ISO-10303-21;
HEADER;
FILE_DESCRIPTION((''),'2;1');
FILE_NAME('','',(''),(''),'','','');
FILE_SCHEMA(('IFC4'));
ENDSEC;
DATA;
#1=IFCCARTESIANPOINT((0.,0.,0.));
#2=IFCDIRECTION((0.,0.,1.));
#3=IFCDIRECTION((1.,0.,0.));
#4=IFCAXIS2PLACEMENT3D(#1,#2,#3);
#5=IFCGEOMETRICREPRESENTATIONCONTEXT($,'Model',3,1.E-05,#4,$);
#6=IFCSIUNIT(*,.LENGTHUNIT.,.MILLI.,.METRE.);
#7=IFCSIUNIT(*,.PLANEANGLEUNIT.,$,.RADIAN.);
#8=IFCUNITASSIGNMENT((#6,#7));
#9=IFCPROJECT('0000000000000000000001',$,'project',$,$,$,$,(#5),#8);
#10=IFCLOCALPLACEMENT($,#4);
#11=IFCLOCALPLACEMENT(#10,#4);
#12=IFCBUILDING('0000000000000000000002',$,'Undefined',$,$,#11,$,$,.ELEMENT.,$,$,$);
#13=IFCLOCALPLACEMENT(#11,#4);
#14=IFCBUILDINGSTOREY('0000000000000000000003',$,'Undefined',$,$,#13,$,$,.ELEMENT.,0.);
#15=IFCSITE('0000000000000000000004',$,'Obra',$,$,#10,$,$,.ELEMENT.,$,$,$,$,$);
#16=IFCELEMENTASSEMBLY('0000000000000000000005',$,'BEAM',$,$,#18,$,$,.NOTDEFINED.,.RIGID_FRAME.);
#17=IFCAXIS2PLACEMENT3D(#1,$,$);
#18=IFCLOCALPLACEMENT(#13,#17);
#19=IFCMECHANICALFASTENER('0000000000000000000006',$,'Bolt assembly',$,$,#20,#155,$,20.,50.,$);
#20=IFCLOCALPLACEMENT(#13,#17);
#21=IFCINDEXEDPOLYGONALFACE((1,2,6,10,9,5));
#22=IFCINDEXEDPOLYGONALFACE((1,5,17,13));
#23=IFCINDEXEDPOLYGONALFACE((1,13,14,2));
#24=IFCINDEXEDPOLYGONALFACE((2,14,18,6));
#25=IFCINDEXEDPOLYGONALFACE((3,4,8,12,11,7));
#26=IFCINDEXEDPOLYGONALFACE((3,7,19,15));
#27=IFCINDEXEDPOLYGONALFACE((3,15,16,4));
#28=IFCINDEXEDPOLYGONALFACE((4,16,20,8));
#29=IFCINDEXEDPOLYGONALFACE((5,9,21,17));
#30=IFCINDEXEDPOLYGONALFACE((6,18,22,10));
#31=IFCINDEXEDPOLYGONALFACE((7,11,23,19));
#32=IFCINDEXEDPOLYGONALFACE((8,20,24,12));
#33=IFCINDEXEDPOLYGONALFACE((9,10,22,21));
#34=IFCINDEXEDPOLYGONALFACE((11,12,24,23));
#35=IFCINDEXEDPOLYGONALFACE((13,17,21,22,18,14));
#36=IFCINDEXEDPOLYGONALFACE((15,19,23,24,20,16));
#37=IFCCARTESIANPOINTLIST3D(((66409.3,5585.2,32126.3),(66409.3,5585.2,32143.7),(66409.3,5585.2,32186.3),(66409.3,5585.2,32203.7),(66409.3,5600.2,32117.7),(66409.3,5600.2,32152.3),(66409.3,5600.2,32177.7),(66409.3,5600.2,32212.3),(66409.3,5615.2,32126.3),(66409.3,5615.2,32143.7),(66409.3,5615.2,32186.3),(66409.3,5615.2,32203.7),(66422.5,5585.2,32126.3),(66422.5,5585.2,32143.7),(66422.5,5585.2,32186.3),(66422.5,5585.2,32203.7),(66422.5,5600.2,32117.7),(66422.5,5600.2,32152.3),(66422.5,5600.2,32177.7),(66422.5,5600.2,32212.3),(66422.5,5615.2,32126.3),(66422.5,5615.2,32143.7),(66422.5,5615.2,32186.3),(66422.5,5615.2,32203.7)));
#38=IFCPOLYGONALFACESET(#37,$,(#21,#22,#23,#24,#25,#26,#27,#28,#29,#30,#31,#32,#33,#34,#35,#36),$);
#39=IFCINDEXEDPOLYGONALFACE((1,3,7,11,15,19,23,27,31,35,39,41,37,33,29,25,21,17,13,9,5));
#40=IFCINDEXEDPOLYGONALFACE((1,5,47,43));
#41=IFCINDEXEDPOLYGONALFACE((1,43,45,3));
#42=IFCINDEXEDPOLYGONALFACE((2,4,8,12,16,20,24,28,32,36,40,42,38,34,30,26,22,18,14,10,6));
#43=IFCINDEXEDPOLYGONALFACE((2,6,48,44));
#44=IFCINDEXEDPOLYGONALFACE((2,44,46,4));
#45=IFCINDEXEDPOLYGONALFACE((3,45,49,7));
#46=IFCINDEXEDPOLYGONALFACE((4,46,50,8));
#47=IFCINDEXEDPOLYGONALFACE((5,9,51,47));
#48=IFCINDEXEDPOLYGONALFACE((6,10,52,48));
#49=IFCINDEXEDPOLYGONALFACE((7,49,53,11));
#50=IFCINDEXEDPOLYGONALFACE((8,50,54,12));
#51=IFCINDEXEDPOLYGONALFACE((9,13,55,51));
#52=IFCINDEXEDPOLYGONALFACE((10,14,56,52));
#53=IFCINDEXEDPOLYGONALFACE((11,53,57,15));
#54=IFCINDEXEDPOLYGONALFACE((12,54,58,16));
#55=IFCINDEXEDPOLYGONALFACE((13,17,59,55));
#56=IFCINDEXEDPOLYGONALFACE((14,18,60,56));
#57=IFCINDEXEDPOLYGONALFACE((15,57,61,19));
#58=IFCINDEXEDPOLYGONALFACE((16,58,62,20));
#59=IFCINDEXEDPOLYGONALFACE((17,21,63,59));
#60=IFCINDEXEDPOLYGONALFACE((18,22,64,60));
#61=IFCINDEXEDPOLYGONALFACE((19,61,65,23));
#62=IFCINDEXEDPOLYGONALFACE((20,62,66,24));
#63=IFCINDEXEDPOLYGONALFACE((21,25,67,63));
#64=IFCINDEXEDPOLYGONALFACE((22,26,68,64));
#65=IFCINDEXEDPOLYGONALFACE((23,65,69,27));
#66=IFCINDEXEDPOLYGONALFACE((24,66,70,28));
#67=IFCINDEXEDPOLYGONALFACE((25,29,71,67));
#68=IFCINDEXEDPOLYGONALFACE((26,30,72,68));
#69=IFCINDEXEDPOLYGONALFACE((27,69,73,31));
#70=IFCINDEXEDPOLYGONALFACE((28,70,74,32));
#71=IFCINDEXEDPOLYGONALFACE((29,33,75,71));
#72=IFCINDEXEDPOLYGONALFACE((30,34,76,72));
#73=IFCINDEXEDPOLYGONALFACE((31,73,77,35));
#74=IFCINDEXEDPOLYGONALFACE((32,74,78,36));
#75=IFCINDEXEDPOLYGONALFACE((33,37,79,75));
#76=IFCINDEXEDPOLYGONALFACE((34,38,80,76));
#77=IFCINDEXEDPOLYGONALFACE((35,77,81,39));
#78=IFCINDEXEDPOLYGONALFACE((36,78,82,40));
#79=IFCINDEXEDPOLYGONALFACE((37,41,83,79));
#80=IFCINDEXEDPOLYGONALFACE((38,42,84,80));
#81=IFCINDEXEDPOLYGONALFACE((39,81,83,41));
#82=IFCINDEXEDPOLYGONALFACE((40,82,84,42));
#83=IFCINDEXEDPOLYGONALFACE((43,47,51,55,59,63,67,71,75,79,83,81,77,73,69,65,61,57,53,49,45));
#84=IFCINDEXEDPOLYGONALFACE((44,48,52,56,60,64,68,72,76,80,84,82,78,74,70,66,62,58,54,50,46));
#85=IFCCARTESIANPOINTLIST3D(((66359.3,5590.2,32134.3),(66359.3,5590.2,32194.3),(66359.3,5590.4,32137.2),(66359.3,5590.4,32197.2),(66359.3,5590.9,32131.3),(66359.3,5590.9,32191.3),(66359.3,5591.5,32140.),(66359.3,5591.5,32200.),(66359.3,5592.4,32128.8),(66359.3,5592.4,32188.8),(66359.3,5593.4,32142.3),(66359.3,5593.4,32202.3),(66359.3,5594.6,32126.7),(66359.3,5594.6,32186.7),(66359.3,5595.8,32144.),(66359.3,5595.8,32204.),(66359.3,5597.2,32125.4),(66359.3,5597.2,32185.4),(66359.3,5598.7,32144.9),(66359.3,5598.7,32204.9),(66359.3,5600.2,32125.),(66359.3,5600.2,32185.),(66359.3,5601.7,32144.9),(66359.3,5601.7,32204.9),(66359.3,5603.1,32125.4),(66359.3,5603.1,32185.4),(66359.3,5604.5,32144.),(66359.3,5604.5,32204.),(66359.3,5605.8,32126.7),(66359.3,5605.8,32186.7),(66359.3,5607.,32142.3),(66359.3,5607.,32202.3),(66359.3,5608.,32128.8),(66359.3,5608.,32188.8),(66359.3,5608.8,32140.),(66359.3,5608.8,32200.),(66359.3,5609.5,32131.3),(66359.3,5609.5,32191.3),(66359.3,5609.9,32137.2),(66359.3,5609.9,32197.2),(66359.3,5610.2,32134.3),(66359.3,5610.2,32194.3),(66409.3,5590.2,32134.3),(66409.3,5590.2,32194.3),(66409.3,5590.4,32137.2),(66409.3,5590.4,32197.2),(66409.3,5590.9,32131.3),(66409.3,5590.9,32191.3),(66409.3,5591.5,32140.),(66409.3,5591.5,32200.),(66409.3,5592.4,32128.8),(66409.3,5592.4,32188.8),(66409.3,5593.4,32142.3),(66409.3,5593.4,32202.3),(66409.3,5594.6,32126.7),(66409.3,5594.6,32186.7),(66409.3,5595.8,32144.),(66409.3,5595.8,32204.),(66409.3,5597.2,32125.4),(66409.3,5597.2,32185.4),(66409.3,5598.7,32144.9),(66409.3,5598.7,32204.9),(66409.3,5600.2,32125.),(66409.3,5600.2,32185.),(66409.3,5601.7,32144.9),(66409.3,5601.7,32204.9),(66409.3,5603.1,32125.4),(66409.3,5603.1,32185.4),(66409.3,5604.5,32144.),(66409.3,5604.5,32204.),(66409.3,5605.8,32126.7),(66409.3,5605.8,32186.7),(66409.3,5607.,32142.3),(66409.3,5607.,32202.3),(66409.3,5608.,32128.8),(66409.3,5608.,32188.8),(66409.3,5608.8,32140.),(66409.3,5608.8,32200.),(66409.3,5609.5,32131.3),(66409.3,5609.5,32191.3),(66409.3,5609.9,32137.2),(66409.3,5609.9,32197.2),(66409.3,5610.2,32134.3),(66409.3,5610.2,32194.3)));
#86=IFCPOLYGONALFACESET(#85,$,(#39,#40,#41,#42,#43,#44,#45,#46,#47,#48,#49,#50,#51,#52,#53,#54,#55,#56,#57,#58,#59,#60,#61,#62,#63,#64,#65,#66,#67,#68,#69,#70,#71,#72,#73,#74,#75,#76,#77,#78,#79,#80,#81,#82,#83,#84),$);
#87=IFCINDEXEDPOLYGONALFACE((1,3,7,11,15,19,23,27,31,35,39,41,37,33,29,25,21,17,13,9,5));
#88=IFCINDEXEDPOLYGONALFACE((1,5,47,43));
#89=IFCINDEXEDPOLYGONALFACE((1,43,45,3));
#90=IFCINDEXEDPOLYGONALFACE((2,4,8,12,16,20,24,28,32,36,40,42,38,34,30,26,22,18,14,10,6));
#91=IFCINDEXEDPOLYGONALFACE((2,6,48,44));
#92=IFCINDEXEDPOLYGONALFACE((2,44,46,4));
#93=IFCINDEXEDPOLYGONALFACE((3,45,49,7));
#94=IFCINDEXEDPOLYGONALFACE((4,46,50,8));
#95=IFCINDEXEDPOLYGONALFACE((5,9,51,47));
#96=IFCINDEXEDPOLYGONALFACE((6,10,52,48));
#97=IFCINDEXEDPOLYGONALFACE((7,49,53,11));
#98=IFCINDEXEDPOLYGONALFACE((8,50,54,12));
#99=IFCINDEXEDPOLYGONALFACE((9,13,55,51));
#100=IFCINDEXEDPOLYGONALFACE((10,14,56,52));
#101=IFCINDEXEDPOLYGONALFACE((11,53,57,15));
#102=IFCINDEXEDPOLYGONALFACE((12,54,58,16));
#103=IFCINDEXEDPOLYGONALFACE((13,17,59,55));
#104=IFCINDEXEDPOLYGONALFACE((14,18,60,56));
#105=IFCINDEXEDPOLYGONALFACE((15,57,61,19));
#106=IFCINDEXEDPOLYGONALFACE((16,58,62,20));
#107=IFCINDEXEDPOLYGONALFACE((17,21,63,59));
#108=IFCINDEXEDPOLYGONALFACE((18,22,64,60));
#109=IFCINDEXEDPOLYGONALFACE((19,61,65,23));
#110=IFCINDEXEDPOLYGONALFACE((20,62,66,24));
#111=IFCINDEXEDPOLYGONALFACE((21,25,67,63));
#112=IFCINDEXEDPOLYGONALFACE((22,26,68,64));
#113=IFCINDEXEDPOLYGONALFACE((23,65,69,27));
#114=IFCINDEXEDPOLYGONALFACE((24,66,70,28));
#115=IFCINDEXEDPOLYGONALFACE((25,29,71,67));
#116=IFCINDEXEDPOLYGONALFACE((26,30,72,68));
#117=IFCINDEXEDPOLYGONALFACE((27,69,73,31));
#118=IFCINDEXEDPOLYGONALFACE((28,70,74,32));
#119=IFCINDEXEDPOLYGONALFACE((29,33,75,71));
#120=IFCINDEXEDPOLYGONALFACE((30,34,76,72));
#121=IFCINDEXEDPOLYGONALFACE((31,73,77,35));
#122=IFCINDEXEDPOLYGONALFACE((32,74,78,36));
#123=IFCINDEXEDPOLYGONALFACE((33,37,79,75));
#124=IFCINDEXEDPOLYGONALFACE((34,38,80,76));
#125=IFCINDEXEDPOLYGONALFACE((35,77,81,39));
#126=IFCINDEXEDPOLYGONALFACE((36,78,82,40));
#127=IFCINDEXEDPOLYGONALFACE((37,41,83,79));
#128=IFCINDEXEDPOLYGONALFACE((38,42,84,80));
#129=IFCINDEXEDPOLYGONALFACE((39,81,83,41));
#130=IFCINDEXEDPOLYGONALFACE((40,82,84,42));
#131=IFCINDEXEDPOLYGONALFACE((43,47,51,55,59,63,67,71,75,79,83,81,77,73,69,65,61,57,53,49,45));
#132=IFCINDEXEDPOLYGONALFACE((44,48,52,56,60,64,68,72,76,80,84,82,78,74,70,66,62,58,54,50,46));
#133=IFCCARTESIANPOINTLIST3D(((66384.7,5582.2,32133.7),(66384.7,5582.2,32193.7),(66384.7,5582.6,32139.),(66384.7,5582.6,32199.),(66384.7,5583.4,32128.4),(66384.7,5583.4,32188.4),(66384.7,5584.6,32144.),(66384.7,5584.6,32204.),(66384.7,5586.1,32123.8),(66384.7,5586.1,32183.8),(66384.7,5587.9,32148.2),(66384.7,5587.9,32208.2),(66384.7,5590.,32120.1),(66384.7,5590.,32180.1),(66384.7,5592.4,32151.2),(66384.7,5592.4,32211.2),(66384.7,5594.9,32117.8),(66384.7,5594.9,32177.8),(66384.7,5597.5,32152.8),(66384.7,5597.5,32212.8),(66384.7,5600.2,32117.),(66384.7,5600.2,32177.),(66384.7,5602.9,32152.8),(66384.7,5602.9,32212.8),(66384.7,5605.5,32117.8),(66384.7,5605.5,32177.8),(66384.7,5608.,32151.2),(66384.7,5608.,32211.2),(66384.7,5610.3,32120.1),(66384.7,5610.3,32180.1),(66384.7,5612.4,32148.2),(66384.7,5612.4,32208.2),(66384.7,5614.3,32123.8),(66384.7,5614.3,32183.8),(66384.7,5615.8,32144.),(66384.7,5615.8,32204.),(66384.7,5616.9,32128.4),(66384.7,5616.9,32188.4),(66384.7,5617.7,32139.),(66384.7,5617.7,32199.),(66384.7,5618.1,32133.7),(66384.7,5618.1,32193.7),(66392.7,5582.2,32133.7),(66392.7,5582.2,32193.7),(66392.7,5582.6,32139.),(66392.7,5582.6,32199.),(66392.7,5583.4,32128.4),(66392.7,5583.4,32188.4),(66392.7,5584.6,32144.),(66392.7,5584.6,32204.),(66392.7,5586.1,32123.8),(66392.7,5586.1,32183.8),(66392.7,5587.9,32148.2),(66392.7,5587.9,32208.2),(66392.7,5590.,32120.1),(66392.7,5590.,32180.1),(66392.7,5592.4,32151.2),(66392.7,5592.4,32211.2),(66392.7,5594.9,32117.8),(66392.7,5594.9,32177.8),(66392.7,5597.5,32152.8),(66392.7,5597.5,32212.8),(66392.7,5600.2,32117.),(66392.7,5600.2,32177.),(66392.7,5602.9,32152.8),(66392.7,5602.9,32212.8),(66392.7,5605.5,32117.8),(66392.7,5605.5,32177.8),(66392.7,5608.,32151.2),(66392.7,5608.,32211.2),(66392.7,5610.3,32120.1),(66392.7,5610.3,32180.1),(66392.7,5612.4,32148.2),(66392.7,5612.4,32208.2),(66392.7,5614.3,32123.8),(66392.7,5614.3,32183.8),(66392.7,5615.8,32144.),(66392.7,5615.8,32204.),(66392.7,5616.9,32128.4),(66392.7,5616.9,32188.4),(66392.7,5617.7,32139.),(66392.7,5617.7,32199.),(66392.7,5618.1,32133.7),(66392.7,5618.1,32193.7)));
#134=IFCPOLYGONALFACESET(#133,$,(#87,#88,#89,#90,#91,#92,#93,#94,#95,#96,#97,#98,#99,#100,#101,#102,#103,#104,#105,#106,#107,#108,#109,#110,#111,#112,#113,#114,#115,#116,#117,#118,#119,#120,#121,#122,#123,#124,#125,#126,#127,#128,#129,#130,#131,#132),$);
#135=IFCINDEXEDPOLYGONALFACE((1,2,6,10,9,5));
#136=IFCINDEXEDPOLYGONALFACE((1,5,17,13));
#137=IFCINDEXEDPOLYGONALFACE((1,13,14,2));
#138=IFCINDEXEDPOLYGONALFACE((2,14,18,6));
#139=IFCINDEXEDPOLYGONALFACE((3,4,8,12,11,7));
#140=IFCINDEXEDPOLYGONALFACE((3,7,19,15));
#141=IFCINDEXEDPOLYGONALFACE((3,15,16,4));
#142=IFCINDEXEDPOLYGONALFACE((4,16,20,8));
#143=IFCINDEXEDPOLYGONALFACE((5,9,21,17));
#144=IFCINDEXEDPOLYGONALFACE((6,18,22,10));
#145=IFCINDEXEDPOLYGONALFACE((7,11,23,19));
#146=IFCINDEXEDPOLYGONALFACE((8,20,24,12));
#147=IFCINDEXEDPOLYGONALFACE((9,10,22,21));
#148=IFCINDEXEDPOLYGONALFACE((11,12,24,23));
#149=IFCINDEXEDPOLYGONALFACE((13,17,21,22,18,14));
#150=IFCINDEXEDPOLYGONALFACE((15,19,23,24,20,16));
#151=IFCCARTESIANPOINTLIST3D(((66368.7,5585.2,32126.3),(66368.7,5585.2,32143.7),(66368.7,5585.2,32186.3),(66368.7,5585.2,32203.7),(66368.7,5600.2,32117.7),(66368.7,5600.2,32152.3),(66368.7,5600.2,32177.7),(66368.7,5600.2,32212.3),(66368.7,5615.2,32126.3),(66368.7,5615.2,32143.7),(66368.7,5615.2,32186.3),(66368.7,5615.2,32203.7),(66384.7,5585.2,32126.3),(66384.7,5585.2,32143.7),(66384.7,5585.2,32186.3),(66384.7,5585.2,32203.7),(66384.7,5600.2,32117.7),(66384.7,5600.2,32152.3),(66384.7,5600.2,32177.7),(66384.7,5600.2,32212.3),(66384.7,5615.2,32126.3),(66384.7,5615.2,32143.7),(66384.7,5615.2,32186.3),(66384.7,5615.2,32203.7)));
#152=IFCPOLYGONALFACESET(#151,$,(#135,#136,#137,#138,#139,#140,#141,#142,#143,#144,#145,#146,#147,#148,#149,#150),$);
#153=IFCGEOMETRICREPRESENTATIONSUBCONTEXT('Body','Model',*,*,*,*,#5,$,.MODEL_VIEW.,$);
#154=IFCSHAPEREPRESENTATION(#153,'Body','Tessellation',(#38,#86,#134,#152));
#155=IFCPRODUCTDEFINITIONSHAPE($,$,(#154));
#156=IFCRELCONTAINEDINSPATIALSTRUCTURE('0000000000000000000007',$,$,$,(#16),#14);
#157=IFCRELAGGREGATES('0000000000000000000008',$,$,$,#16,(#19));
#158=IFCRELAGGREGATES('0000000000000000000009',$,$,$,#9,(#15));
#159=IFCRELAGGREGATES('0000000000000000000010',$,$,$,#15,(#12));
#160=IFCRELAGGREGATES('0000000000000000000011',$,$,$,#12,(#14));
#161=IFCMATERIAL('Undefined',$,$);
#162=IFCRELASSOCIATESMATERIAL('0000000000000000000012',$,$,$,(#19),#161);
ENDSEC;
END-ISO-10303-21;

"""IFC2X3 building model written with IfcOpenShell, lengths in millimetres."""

from ifc_helpers import new_model, si_unit, frame, origin_with_axes, origin_2d_with_axis, place, context, subcontext, project, spatial, polyline, circle, outline, extrude, source, transform, mapped, material, element, aggregate, save


model = new_model("IFC2X3")

# Units and contexts
model_context = context("Model", 3, precision=1e-05, world=origin_with_axes())
body_context = subcontext(model_context, "Body", "Model", "MODEL_VIEW")
ifc_project = project(units=[si_unit("LENGTHUNIT", "METRE", prefix="MILLI"), si_unit("PLANEANGLEUNIT", "RADIAN")], contexts=[model_context])

# Site, building, storey
site_placement = place(None, origin_with_axes())
site = spatial("IfcSite", under=ifc_project, at=site_placement, Name="Obra", CompositionType="ELEMENT")
building_placement = place(site_placement, origin_with_axes())
building = spatial("IfcBuilding", under=site, at=building_placement, Name="Undefined", CompositionType="ELEMENT")
storey_placement = place(building_placement, origin_with_axes())
storey = spatial("IfcBuildingStorey", under=building, at=storey_placement, Name="Undefined", CompositionType="ELEMENT", Elevation=0.0)

# Element assembly
assembly_1_placement = place(storey_placement, origin_with_axes())
assembly_1 = element("IfcElementAssembly", 1, at=assembly_1_placement, inside=storey, Name="BEAM", AssemblyPlace="NOTDEFINED", PredefinedType="RIGID_FRAME")

# Mechanical fastener
ifc_material_1 = material(Name="Undefined")
shared_shape_1 = source(origin_with_axes(), body_context, "Body", "SweptSolid", [
    extrude(outline(polyline([(17.3, 0.0), (8.7, 15.0), (-8.7, 15.0), (-17.3, 0.0), (-8.7, -15.0), (8.7, -15.0), (17.3, 0.0)])), frame((0.0, -26.5, 0.0), z_axis=(0.0, 1.0, 0.0), x_axis=(1.0, 0.0, 0.0)), (0.0, 0.0, 1.0), 13.2),
    extrude(circle(Radius=10.0, at=origin_2d_with_axis()), frame((0.0, -13.3, 0.0), z_axis=(0.0, 1.0, 0.0), x_axis=(1.0, 0.0, 0.0)), (0.0, 0.0, 1.0), 50.0),
    extrude(circle(Radius=18.0, at=origin_2d_with_axis()), frame((0.0, 3.3, 0.0), z_axis=(0.0, 1.0, 0.0), x_axis=(1.0, 0.0, 0.0)), (0.0, 0.0, 1.0), 8.0),
    extrude(outline(polyline([(17.3, 0.0), (8.7, 15.0), (-8.7, 15.0), (-17.3, 0.0), (-8.7, -15.0), (8.7, -15.0), (17.3, 0.0)])), frame((0.0, 11.3, 0.0), z_axis=(0.0, 1.0, 0.0), x_axis=(1.0, 0.0, 0.0)), (0.0, 0.0, 1.0), 16.0),
])
mechanical_fastener_1_placement = place(assembly_1_placement, frame((66396.0, 5560.2, 32235.0), z_axis=(0.0, 1.0, 0.0), x_axis=(0.0, 0.0, -1.0)))
mechanical_fastener_1 = element("IfcMechanicalFastener", 2, at=mechanical_fastener_1_placement, material=ifc_material_1, Name="Bolt assembly", NominalDiameter=20.0, NominalLength=50.0, context=body_context, shape_type="MappedRepresentation", body=[
    mapped(shared_shape_1, transform((40.0, 0.0, 40.0))),
    mapped(shared_shape_1, transform((100.0, 0.0, 40.0))),
])
aggregate(assembly_1, [mechanical_fastener_1])

save(model, "model.ifc")
